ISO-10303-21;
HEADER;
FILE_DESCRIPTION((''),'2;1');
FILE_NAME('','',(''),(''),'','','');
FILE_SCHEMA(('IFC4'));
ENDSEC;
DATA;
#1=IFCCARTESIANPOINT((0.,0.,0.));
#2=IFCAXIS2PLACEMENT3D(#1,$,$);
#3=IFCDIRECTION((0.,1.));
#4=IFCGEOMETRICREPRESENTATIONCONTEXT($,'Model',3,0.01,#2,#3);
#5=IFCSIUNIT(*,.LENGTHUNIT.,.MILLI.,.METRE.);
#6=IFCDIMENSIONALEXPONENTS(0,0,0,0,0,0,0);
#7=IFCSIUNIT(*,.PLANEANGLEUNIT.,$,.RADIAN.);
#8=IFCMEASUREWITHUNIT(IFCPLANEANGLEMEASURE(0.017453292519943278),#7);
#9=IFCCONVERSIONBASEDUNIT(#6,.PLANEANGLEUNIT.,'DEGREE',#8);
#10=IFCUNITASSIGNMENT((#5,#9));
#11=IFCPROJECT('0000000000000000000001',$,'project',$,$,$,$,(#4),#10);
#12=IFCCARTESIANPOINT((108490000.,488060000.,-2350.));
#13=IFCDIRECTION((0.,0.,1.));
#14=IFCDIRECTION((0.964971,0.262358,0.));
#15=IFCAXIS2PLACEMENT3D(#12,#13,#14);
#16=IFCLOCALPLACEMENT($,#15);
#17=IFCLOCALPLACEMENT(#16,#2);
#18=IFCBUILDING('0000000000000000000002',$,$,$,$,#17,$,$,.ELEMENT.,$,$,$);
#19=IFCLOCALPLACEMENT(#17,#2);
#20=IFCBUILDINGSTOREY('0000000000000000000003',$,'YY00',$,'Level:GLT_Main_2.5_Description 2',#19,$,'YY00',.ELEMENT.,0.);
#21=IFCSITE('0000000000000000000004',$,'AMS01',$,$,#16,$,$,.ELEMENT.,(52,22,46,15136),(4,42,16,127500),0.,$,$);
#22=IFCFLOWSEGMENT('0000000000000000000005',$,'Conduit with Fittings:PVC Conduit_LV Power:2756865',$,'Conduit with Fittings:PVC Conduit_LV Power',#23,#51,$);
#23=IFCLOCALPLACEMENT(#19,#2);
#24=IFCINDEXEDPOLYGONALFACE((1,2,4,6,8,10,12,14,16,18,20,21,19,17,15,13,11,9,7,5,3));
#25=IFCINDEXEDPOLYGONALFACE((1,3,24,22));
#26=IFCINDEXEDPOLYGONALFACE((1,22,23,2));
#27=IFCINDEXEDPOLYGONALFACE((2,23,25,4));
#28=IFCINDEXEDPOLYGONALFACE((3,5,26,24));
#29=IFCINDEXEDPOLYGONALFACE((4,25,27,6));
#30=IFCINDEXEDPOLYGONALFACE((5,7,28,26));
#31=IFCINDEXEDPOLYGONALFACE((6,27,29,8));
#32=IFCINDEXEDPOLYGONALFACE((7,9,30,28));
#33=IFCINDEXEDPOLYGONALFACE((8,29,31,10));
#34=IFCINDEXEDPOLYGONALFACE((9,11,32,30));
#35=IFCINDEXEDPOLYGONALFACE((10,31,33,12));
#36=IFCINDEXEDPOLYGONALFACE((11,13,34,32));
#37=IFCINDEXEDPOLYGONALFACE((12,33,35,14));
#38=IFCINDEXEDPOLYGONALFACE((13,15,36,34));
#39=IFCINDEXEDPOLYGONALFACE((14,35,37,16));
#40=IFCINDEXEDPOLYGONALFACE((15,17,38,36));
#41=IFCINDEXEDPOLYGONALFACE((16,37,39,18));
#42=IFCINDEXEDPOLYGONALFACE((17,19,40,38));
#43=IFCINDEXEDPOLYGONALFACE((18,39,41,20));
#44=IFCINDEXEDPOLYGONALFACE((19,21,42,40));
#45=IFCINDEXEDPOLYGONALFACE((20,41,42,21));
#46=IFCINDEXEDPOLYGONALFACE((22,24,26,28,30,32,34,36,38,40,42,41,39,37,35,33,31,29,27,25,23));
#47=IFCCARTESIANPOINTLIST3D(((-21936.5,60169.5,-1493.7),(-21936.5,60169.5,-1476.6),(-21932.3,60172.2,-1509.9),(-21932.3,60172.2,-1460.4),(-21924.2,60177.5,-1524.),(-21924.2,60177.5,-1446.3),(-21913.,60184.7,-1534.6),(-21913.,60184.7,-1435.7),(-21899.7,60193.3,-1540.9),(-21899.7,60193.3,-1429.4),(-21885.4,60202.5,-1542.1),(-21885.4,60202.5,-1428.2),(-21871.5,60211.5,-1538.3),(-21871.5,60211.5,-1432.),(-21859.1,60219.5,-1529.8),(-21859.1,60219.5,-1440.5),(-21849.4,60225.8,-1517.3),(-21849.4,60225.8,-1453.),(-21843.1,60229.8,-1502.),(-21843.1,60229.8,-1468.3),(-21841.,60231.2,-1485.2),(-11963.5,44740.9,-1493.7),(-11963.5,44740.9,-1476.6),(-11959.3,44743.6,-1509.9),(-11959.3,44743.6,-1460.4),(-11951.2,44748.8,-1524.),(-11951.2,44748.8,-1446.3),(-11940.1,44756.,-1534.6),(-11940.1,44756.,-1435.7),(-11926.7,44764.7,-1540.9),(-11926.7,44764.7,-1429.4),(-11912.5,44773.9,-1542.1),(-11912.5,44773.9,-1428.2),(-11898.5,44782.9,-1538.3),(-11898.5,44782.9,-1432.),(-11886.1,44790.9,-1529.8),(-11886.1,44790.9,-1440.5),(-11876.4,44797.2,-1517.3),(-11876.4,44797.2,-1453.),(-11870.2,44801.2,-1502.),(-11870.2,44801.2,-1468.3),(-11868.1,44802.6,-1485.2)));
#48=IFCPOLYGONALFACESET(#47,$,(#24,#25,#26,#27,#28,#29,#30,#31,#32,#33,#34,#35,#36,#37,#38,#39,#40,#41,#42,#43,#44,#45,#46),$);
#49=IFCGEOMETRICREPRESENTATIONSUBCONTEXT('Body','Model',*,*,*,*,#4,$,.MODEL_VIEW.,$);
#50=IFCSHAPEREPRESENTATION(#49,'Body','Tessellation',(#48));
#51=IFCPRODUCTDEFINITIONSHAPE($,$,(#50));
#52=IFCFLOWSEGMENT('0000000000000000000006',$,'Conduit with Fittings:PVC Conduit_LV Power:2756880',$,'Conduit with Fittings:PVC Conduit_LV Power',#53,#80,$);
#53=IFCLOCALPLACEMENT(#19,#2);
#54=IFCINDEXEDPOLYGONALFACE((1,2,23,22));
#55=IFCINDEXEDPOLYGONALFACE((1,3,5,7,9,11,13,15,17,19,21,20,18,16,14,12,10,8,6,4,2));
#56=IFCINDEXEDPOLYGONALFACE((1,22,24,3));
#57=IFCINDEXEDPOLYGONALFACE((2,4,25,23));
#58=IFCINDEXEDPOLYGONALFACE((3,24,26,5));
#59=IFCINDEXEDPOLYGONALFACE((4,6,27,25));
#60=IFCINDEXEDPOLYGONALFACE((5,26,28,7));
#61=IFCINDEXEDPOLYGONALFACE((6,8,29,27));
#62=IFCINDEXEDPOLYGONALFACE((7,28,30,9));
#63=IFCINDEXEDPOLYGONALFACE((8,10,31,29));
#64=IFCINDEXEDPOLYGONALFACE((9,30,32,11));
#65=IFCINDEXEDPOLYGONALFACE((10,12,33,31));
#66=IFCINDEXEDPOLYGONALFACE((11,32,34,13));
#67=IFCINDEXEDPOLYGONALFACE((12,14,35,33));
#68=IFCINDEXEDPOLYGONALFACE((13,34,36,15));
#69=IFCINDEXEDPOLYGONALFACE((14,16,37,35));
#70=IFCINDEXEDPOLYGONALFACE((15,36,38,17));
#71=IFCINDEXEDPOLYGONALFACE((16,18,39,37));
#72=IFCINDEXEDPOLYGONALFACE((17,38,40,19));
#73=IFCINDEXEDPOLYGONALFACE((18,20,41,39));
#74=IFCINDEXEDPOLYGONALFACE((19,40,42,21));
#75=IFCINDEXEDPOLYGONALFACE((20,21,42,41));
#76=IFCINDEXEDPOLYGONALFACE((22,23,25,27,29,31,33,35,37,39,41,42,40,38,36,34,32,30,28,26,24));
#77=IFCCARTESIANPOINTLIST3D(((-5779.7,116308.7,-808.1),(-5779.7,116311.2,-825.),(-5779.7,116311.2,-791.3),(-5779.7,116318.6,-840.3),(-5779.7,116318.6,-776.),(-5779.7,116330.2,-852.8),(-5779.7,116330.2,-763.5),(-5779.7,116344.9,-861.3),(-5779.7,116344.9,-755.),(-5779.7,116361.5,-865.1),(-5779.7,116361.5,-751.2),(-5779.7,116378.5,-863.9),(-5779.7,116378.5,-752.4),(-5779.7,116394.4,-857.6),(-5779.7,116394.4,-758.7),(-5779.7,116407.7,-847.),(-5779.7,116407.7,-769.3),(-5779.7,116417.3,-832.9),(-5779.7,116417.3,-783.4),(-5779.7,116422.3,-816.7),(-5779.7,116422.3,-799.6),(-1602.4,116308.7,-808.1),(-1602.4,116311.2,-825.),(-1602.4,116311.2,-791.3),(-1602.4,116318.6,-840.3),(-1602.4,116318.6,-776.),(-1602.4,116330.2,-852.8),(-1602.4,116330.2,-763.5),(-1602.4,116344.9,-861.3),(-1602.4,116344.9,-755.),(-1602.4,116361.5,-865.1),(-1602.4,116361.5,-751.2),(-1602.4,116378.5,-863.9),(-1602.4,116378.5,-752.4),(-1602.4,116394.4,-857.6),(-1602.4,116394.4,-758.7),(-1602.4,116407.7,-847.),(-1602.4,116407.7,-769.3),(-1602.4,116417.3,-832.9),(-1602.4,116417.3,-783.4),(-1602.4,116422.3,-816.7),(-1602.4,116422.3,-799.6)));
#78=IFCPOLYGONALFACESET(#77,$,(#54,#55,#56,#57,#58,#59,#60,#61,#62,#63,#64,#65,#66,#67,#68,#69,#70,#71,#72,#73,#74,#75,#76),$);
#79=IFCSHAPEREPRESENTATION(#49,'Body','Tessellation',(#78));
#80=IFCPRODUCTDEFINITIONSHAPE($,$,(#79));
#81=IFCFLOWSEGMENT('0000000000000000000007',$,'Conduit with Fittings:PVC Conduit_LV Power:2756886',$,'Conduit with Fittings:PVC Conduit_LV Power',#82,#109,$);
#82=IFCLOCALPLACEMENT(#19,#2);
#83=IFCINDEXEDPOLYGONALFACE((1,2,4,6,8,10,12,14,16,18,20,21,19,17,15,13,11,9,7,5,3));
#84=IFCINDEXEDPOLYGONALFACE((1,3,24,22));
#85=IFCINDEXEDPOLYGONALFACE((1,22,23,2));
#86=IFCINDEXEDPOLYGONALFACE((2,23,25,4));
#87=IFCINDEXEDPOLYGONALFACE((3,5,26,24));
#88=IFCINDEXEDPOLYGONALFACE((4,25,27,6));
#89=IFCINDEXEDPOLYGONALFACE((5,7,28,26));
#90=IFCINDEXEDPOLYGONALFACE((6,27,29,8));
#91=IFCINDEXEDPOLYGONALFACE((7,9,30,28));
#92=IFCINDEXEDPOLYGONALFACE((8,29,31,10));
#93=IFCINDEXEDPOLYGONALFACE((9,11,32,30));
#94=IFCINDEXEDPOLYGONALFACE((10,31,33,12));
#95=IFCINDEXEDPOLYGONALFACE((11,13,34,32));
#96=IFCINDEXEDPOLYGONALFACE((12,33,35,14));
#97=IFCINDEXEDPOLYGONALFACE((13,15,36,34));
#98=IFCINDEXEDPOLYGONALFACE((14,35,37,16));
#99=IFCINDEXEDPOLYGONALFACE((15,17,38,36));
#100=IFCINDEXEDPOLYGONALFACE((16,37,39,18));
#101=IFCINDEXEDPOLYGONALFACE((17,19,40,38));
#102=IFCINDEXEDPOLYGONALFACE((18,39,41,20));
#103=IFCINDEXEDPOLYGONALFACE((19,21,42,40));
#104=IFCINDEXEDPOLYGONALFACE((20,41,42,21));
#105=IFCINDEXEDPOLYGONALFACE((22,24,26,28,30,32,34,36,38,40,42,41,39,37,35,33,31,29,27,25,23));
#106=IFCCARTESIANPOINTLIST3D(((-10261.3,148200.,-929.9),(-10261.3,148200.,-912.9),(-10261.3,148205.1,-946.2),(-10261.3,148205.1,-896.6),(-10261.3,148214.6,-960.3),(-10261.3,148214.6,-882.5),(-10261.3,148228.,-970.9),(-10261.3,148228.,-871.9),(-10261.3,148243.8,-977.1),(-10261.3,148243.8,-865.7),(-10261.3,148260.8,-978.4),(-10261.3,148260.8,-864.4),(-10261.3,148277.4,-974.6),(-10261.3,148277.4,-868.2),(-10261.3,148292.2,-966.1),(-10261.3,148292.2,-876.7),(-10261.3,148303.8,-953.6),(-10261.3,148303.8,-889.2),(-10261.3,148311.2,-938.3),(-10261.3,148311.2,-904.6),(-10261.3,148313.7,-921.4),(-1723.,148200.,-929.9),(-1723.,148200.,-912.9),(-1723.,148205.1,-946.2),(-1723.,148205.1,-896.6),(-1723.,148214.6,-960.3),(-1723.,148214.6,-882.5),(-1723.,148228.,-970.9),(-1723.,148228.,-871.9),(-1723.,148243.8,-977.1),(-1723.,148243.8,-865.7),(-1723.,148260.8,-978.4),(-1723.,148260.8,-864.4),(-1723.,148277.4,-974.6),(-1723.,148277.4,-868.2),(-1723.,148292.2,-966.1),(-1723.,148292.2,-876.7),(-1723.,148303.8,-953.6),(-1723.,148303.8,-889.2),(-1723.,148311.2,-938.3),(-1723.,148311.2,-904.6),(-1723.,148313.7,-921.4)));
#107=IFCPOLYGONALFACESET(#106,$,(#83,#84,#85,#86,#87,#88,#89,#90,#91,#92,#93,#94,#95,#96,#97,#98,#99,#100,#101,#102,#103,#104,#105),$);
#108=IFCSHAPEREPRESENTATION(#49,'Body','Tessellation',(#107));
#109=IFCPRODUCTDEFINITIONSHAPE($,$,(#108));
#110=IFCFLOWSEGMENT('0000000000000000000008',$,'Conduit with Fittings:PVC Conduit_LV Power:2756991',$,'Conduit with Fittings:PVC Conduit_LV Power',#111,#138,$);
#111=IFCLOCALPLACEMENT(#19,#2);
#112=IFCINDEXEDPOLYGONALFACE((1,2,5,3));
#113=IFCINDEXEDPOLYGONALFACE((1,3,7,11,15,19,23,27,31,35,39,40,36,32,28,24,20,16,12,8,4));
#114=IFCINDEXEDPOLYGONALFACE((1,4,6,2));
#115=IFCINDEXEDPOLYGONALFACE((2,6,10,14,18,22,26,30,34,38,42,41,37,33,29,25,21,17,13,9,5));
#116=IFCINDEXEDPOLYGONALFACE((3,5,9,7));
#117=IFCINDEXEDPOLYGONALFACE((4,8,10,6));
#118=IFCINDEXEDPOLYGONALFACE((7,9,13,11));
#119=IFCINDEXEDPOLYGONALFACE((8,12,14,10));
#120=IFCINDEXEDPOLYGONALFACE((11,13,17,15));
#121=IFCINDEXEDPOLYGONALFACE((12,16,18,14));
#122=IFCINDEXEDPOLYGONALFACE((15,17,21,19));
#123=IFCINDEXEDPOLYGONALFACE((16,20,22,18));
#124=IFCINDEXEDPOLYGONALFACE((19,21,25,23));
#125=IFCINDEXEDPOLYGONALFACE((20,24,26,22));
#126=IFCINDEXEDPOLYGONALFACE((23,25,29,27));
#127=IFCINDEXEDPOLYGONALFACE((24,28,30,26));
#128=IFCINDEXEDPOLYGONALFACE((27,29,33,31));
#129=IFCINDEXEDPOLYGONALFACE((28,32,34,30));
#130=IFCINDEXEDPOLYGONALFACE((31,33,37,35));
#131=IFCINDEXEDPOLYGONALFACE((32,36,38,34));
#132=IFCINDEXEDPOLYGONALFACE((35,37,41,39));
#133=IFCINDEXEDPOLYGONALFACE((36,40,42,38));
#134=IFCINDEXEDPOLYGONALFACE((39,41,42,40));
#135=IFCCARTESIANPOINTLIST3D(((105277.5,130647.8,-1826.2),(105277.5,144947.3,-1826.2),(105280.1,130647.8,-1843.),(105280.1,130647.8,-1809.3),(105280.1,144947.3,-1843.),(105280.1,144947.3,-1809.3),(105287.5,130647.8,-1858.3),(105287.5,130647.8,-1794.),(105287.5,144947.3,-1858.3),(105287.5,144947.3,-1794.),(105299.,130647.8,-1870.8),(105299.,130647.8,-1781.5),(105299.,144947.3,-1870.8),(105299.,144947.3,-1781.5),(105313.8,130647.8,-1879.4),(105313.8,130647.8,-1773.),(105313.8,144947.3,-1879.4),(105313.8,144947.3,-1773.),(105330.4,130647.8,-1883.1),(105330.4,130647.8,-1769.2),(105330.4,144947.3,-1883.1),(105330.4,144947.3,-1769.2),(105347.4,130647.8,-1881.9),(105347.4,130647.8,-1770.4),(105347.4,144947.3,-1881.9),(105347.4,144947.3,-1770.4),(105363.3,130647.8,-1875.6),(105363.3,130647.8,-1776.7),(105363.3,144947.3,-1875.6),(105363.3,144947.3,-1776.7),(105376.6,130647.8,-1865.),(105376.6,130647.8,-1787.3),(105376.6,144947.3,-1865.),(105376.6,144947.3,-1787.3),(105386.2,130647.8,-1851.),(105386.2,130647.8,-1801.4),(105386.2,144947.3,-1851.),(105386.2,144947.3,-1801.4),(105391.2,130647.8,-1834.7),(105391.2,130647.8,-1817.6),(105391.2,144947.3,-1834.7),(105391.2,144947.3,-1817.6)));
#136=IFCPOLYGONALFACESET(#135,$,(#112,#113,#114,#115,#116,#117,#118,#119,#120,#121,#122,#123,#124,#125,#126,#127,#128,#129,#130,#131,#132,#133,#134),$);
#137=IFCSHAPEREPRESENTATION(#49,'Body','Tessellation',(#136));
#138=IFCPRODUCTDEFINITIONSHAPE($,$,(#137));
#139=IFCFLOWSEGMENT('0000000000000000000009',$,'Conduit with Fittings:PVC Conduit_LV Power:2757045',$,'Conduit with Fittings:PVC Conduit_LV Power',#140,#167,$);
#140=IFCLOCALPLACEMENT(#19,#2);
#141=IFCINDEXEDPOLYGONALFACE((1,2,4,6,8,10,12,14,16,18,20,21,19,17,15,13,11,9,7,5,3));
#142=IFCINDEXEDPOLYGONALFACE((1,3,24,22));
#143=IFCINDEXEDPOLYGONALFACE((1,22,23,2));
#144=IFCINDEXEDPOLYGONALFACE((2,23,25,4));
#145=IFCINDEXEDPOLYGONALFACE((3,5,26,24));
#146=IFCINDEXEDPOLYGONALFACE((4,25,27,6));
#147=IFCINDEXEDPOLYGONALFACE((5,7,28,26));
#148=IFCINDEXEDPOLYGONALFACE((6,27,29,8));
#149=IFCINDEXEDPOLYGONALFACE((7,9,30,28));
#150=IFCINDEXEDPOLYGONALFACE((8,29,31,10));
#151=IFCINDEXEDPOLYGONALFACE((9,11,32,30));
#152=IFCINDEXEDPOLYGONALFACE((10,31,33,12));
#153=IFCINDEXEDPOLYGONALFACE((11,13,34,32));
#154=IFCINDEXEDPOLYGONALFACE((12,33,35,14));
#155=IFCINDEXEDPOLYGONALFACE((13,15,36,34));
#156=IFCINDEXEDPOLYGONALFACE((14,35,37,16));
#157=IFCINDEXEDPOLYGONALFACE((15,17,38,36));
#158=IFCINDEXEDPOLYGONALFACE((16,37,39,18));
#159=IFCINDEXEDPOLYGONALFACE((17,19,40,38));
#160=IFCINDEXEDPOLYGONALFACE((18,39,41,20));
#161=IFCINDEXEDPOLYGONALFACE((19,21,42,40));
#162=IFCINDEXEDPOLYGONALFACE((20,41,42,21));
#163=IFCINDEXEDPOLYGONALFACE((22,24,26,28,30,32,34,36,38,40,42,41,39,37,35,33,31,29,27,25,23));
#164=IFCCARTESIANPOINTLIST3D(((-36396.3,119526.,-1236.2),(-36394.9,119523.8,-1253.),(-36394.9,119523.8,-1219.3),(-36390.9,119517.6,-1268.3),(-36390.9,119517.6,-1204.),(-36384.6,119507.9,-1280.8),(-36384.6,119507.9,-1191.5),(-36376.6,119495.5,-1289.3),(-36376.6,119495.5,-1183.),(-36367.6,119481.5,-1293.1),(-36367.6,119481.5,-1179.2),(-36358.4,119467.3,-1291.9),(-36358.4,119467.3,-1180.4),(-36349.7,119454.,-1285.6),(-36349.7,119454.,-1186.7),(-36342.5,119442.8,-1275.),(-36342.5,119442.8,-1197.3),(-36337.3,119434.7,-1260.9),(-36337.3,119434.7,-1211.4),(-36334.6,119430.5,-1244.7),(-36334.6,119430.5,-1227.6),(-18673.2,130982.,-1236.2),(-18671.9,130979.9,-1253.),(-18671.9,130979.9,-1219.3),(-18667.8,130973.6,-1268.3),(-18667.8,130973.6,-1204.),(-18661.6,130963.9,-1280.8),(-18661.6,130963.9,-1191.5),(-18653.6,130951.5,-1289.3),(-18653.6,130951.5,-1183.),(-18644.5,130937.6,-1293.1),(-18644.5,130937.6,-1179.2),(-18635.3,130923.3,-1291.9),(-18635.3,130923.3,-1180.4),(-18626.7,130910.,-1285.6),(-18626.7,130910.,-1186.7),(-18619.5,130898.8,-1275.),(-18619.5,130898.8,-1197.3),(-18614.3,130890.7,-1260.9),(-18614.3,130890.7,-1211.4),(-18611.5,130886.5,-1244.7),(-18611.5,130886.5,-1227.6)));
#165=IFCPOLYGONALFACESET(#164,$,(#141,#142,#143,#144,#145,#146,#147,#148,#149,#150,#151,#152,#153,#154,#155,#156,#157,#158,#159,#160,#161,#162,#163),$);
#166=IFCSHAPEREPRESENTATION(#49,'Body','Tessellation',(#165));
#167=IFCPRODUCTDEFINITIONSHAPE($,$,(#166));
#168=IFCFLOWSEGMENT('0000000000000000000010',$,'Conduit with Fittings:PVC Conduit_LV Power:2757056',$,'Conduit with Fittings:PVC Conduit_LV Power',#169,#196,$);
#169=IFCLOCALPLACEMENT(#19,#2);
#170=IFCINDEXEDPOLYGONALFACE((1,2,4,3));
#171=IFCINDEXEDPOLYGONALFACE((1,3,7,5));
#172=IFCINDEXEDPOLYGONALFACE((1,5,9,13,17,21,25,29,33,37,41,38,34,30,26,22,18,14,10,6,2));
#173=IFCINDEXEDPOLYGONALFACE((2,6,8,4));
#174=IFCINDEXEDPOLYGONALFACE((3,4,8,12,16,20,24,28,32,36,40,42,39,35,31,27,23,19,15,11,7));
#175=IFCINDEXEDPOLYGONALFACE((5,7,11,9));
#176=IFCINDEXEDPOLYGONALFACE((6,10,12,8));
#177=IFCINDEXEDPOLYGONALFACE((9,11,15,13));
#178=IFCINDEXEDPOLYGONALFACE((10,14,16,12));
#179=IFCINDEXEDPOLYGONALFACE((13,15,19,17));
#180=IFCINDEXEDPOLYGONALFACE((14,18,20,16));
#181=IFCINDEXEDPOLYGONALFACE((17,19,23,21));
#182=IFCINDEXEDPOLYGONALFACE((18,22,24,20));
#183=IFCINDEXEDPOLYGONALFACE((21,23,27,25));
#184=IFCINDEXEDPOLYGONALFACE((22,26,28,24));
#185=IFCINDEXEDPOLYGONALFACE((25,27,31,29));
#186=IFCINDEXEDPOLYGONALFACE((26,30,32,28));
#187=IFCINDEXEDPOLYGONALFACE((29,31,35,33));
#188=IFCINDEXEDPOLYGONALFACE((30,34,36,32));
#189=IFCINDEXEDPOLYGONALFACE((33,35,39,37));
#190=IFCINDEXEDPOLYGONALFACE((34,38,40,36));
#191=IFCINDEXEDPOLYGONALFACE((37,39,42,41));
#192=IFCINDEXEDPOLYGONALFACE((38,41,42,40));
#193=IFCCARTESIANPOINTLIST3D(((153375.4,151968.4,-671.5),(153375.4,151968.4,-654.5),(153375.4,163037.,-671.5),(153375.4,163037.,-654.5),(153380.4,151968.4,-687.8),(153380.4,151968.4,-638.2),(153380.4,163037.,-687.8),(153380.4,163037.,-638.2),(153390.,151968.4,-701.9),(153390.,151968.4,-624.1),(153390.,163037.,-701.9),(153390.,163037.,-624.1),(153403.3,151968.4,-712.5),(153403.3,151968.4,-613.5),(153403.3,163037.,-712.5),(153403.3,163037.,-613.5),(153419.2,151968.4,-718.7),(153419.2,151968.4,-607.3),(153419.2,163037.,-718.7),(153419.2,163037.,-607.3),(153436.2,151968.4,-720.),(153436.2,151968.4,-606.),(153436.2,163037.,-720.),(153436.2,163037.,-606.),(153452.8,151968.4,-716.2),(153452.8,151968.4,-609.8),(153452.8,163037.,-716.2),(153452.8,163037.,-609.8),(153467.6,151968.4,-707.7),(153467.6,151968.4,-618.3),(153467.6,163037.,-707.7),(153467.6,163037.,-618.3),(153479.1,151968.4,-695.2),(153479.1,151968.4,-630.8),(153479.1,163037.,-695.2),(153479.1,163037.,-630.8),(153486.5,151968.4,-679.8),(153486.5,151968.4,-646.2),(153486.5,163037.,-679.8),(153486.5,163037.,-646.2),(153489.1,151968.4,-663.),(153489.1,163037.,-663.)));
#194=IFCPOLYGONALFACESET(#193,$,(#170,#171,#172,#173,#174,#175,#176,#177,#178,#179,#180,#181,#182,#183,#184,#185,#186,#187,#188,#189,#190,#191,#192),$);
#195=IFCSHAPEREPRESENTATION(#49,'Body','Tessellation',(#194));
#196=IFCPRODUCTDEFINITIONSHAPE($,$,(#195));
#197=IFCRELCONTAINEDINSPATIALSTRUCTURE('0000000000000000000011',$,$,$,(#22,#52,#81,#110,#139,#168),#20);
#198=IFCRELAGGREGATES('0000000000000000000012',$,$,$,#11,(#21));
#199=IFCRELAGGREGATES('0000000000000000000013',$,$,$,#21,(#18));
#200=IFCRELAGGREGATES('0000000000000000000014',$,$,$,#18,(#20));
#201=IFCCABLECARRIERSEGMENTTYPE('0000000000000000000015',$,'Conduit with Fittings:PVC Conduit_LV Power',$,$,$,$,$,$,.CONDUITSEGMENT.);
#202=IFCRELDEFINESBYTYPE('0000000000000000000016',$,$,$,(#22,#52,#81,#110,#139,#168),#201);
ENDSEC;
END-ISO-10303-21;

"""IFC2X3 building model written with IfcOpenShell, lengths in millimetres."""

from ifc_helpers import new_model, entity, si_unit, converted_unit, direction, frame, frame_2d, origin, origin_2d_with_axis, place, context, subcontext, project, spatial, circle, extrude, type_object, element, save


model = new_model("IFC2X3")

# Units and contexts
model_context = context("Model", 3, precision=0.01, world=origin(), true_north=direction((0.0, 1.0)))
body_context = subcontext(model_context, "Body", "Model", "MODEL_VIEW")
ifc_project = project(units=[si_unit("LENGTHUNIT", "METRE", prefix="MILLI"), converted_unit("PLANEANGLEUNIT", "DEGREE", entity("IfcPlaneAngleMeasure", 0.017453292519943278), si_unit("PLANEANGLEUNIT", "RADIAN"), dimensions=[0, 0, 0, 0, 0, 0, 0])], contexts=[model_context])

# Site, building, storey
site_placement = place(None, frame((108490000.0, 488060000.0, -2350.0), z_axis=(0.0, 0.0, 1.0), x_axis=(0.964971, 0.262358, 0.0)))
site = spatial("IfcSite", under=ifc_project, at=site_placement, Name="AMS01", CompositionType="ELEMENT", RefLatitude=(52, 22, 46, 15136), RefLongitude=(4, 42, 16, 127500), RefElevation=0.0)
building_placement = place(site_placement, origin())
building = spatial("IfcBuilding", under=site, at=building_placement, CompositionType="ELEMENT")
storey_placement = place(building_placement, origin())
storey = spatial("IfcBuildingStorey", under=building, at=storey_placement, Name="YY00", ObjectType="Level:GLT_Main_2.5_Description 2", LongName="YY00", CompositionType="ELEMENT", Elevation=0.0)

# Flow segments
cable_carrier_segment_type = type_object("IfcCableCarrierSegmentType", Name="Conduit with Fittings:PVC Conduit_LV Power", PredefinedType="CONDUITSEGMENT")
flow_segment_1_placement = place(storey_placement, origin())
element("IfcFlowSegment", 1, at=flow_segment_1_placement, inside=storey, type_object=cable_carrier_segment_type, Name="Conduit with Fittings:PVC Conduit_LV Power:2756865", ObjectType="Conduit with Fittings:PVC Conduit_LV Power", context=body_context, shape_type="SweptSolid", body=[
    extrude(circle(Radius=57.2, at=origin_2d_with_axis()), frame((-11916.1, 44771.6, -1485.2), z_axis=(-0.542856, 0.839826, 0.0), x_axis=(0.839826, 0.542856, 0.0)), (0.0, 0.0, 1.0), 18371.2),
])
flow_segment_2_placement = place(storey_placement, origin())
element("IfcFlowSegment", 2, at=flow_segment_2_placement, inside=storey, type_object=cable_carrier_segment_type, Name="Conduit with Fittings:PVC Conduit_LV Power:2756880", ObjectType="Conduit with Fittings:PVC Conduit_LV Power", context=body_context, shape_type="SweptSolid", body=[
    extrude(circle(Radius=57.2, at=origin_2d_with_axis()), frame((-5779.7, 116365.8, -808.1), z_axis=(1.0, 0.0, 0.0), x_axis=(0.0, -1.0, 0.0)), (0.0, 0.0, 1.0), 4177.3),
])
flow_segment_3_placement = place(storey_placement, origin())
element("IfcFlowSegment", 3, at=flow_segment_3_placement, inside=storey, type_object=cable_carrier_segment_type, Name="Conduit with Fittings:PVC Conduit_LV Power:2756886", ObjectType="Conduit with Fittings:PVC Conduit_LV Power", context=body_context, shape_type="SweptSolid", body=[
    extrude(circle(Radius=57.2, at=frame_2d((0.0, 0.0), x_axis=(1.0, 0.0))), frame((-10261.3, 148256.5, -921.4), z_axis=(1.0, 0.0, 0.0), x_axis=(0.0, 1.0, 0.0)), (0.0, 0.0, 1.0), 8538.3),
])
flow_segment_4_placement = place(storey_placement, origin())
element("IfcFlowSegment", 4, at=flow_segment_4_placement, inside=storey, type_object=cable_carrier_segment_type, Name="Conduit with Fittings:PVC Conduit_LV Power:2756991", ObjectType="Conduit with Fittings:PVC Conduit_LV Power", context=body_context, shape_type="SweptSolid", body=[
    extrude(circle(Radius=57.2, at=frame_2d((0.0, 0.0), x_axis=(1.0, 0.0))), frame((105334.7, 130647.8, -1826.2), z_axis=(0.0, 1.0, 0.0), x_axis=(-1.0, 0.0, 0.0)), (0.0, 0.0, 1.0), 14299.5),
])
flow_segment_5_placement = place(storey_placement, origin())
element("IfcFlowSegment", 5, at=flow_segment_5_placement, inside=storey, type_object=cable_carrier_segment_type, Name="Conduit with Fittings:PVC Conduit_LV Power:2757045", ObjectType="Conduit with Fittings:PVC Conduit_LV Power", context=body_context, shape_type="SweptSolid", body=[
    extrude(circle(Radius=57.2, at=frame_2d((0.0, 0.0), x_axis=(1.0, 0.0))), frame((-36365.3, 119478.0, -1236.2), z_axis=(0.839826, 0.542856, 0.0), x_axis=(-0.542856, 0.839826, 0.0)), (0.0, 0.0, 1.0), 21103.2),
])
flow_segment_6_placement = place(storey_placement, origin())
element("IfcFlowSegment", 6, at=flow_segment_6_placement, inside=storey, type_object=cable_carrier_segment_type, Name="Conduit with Fittings:PVC Conduit_LV Power:2757056", ObjectType="Conduit with Fittings:PVC Conduit_LV Power", context=body_context, shape_type="SweptSolid", body=[
    extrude(circle(Radius=57.2, at=origin_2d_with_axis()), frame((153431.9, 151968.4, -663.0), z_axis=(0.0, 1.0, 0.0), x_axis=(1.0, 0.0, 0.0)), (0.0, 0.0, 1.0), 11068.6),
])

save(model, "model.ifc")
